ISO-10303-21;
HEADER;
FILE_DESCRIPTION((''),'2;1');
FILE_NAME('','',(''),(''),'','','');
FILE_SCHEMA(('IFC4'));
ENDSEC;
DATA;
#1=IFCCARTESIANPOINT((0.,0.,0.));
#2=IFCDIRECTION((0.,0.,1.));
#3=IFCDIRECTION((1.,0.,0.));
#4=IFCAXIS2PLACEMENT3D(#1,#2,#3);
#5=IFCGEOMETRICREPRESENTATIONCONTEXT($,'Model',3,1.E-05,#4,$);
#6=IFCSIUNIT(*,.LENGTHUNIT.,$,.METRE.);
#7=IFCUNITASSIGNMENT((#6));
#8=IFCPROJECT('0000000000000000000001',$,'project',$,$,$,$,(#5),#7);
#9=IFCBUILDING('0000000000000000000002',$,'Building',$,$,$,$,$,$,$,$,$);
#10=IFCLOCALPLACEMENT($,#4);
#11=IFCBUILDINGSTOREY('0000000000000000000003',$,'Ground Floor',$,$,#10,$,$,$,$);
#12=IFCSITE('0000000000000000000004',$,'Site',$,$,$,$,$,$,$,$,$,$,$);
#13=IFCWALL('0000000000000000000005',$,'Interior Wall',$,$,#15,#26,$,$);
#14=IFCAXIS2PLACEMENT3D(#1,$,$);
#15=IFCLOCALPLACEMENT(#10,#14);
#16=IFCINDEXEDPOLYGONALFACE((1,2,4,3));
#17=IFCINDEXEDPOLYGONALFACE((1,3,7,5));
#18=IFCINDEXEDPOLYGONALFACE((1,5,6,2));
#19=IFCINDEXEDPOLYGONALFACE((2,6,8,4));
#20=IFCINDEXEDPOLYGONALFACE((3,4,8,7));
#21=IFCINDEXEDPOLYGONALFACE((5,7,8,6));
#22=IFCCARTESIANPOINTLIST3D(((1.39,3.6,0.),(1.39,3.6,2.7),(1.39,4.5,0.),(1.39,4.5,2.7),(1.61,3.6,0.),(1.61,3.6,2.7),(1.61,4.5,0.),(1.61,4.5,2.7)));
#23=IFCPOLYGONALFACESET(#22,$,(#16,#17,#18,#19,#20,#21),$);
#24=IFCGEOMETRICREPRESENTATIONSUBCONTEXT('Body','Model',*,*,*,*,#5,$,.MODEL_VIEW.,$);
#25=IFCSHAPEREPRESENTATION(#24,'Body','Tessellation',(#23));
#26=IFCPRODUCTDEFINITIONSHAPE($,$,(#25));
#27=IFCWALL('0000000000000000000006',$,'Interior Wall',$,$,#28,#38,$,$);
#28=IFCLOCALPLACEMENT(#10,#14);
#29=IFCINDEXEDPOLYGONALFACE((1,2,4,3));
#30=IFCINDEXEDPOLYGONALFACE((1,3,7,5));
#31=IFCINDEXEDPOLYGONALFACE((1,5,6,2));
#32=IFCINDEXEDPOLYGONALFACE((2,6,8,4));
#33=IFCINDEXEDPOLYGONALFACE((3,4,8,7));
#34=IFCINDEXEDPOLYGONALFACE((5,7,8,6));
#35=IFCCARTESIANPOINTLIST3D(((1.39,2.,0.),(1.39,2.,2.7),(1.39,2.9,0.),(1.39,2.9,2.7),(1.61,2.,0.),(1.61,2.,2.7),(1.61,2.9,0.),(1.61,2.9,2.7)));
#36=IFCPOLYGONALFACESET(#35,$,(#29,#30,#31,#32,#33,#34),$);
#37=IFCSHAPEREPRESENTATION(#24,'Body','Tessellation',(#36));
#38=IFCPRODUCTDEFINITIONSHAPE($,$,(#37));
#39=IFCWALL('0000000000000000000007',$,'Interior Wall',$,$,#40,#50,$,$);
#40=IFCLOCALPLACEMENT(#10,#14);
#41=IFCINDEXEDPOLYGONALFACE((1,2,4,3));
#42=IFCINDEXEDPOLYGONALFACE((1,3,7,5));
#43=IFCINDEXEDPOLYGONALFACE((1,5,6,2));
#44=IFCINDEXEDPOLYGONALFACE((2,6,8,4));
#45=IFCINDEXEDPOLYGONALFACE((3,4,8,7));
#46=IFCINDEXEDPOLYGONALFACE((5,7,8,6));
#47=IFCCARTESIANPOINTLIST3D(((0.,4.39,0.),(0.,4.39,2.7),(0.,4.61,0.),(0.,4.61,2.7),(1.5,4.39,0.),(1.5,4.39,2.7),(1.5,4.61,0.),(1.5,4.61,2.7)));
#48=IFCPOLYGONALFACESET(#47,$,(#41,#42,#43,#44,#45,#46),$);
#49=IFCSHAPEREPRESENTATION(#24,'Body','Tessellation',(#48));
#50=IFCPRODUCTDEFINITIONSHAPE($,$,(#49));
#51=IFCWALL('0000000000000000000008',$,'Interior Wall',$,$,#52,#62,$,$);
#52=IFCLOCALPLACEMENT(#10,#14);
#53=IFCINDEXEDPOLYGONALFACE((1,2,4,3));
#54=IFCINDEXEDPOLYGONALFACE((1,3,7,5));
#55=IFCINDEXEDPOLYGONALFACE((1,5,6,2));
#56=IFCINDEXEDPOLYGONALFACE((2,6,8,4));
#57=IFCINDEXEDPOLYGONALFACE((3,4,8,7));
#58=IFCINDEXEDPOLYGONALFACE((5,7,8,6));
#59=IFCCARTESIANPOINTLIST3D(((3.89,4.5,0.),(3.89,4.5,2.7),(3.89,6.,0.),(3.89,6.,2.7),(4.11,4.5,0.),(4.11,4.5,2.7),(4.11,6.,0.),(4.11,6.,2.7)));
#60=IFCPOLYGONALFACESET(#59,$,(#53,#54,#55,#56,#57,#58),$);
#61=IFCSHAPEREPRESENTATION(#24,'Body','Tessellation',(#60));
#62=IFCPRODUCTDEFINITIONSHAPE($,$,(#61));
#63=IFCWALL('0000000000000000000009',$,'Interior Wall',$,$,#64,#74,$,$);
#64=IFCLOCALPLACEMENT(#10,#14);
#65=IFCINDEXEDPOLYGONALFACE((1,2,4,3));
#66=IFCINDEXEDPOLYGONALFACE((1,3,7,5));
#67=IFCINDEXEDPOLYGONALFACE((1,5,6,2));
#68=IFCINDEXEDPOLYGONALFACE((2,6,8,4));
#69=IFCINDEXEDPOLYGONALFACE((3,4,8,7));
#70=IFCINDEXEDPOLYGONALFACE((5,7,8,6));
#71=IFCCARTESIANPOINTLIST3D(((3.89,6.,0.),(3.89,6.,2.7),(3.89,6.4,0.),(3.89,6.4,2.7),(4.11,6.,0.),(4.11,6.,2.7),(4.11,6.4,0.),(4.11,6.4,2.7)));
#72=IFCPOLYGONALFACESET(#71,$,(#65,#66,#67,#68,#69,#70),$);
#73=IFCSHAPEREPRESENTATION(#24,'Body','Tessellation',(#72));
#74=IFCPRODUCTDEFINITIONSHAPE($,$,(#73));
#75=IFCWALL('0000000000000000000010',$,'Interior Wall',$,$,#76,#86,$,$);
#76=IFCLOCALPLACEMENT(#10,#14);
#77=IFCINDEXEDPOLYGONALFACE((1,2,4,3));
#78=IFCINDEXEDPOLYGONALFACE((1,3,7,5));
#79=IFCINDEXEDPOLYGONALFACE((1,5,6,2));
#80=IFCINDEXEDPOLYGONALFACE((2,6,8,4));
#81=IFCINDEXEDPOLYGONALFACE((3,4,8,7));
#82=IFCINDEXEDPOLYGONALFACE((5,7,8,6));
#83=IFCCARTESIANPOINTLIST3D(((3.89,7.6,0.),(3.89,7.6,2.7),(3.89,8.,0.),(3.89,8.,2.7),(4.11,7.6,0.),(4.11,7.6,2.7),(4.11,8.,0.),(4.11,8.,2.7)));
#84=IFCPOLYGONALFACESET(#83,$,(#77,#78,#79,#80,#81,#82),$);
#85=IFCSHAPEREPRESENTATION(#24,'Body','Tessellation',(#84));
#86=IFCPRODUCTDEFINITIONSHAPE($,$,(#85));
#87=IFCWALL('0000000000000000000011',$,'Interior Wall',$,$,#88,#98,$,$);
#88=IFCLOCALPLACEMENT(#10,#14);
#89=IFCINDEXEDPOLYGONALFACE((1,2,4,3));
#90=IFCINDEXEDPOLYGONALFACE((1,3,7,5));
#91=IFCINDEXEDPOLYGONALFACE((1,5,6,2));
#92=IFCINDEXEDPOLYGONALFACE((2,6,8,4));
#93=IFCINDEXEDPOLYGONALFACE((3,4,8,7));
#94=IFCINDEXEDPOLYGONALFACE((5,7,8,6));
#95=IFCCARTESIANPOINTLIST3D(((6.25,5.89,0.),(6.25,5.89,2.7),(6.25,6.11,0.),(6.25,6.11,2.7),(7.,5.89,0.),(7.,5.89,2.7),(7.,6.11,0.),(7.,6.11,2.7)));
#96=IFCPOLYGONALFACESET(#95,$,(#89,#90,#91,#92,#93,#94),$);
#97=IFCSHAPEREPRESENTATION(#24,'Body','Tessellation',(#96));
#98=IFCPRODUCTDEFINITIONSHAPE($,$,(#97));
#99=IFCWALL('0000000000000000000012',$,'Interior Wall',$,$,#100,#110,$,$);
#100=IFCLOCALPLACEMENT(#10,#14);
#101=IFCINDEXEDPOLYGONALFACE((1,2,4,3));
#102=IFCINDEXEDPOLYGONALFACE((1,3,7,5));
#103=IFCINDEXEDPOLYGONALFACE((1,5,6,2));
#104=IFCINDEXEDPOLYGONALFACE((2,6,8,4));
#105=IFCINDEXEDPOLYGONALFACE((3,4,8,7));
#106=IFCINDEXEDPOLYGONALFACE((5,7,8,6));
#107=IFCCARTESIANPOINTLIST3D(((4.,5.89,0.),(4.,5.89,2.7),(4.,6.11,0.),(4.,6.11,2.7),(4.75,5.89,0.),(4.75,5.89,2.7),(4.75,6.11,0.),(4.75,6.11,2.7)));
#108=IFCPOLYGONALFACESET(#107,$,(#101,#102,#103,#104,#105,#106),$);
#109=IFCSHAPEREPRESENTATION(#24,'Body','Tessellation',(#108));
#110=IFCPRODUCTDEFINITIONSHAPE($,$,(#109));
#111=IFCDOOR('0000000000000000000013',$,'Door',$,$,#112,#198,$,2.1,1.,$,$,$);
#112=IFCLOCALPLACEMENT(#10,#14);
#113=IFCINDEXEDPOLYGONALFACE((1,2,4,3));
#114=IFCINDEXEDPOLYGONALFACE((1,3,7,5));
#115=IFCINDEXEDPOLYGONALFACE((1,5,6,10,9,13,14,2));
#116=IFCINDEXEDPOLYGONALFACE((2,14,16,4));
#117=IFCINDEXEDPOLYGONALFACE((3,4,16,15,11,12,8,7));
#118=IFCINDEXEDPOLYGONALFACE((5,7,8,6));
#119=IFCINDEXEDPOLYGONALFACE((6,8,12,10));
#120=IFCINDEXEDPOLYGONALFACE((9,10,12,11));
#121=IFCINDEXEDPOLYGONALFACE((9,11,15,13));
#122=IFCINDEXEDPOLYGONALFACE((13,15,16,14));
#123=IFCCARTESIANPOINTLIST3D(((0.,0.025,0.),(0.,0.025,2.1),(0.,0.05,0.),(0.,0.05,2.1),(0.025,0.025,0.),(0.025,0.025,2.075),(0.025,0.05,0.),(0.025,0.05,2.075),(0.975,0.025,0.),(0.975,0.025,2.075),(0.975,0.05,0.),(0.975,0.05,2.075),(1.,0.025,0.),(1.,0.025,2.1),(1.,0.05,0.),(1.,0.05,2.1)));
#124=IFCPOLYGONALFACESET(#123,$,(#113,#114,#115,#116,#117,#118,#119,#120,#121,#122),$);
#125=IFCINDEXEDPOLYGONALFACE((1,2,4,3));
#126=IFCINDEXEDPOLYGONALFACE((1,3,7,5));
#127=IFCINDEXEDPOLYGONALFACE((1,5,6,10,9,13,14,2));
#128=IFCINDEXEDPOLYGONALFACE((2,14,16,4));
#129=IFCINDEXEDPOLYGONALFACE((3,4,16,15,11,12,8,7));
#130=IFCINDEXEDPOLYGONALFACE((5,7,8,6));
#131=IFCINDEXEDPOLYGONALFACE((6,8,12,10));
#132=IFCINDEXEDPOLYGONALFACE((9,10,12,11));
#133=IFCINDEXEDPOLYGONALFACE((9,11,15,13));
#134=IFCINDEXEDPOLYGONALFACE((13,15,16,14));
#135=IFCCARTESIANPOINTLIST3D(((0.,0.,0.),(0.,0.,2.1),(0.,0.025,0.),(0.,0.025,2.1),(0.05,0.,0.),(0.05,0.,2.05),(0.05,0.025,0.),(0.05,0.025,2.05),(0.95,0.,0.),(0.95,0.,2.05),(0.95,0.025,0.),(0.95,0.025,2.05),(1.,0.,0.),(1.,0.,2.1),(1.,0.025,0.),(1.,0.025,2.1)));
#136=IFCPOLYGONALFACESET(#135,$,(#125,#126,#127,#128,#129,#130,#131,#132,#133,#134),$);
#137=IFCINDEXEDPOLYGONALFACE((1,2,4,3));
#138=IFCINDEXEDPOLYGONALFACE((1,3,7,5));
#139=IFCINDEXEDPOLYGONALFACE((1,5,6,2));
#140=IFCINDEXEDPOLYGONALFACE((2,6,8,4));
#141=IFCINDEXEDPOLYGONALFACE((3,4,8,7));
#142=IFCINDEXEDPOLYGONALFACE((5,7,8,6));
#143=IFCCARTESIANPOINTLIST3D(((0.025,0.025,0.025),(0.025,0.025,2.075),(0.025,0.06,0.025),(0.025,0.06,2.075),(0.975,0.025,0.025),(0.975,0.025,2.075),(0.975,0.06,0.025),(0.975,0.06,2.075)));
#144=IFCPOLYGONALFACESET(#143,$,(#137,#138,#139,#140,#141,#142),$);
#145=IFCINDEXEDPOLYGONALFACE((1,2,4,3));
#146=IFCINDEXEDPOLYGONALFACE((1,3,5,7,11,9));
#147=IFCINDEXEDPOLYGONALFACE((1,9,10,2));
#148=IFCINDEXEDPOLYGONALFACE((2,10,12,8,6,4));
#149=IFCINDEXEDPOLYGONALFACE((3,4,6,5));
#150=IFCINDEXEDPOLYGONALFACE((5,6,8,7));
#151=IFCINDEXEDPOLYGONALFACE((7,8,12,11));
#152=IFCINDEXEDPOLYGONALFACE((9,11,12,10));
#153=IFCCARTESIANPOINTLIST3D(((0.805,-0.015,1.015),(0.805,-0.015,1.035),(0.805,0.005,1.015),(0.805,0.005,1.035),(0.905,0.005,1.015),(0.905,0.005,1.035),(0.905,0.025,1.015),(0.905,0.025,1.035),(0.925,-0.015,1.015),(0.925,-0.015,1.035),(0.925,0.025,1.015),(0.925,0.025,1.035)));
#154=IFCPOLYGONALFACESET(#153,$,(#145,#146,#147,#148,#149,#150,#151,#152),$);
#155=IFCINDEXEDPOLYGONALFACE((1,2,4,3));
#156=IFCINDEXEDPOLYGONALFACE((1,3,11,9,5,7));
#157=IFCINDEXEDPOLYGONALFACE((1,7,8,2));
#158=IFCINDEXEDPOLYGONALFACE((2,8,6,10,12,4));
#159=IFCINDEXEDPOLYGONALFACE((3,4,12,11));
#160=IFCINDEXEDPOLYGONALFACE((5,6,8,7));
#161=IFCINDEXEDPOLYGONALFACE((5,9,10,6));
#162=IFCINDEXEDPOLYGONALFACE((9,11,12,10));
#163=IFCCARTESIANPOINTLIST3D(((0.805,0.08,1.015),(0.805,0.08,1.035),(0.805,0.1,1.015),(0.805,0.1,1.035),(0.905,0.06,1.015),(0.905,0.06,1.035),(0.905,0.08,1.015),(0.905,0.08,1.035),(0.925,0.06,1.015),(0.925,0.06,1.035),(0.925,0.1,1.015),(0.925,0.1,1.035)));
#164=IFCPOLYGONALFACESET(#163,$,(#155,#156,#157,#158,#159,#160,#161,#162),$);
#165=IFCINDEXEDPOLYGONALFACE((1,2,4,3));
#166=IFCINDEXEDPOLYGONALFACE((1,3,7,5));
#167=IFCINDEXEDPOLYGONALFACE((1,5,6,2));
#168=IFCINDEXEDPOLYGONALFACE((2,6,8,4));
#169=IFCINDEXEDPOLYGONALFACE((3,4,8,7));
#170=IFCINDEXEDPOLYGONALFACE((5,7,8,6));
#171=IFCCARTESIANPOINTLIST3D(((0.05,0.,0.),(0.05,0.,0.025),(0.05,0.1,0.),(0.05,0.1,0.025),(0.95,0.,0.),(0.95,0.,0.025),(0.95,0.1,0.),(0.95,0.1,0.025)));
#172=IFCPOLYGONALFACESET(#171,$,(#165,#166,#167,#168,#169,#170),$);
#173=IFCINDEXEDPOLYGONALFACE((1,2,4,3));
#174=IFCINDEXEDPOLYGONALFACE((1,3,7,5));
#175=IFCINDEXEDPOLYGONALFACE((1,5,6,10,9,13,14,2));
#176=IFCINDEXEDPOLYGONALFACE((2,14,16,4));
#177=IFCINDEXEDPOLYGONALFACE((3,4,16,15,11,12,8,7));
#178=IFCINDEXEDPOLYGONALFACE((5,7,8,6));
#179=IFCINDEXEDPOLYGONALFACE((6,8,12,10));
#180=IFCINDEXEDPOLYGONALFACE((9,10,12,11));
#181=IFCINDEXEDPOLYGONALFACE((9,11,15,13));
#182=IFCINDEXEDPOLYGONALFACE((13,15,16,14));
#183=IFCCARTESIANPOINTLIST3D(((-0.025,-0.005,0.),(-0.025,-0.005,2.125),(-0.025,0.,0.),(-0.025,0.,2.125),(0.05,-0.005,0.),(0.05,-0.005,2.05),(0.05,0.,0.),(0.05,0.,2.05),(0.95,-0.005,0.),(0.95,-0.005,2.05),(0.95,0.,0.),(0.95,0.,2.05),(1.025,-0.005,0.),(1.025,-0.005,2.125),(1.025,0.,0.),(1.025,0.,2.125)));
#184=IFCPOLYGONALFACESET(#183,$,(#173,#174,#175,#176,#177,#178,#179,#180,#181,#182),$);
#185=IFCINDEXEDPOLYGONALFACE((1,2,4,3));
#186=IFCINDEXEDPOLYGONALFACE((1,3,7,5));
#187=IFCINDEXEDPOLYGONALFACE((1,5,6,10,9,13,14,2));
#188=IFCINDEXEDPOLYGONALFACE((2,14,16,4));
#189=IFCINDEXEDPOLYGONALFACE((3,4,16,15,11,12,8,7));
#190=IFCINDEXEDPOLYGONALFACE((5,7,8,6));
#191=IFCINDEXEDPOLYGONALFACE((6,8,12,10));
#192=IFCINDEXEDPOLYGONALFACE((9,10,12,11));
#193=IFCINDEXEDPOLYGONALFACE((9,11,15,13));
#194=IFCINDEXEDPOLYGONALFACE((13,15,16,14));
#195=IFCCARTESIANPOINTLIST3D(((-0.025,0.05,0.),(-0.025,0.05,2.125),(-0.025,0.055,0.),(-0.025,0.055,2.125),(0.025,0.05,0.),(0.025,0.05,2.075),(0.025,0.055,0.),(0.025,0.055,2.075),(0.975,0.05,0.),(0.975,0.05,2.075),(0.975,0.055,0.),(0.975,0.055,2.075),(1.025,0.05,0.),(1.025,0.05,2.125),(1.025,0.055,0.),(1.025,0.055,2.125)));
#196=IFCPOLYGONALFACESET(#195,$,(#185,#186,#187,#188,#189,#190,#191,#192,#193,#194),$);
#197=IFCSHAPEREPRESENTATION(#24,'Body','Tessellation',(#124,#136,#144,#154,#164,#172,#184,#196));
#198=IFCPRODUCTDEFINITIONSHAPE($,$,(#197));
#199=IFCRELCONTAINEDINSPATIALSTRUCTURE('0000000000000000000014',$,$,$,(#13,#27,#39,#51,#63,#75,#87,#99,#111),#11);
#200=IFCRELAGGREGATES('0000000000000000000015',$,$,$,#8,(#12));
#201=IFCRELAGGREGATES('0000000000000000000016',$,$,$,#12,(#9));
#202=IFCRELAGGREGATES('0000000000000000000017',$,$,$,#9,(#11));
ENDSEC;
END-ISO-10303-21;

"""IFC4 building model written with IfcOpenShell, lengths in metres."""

from ifc_helpers import new_model, si_unit, frame, origin_with_axes, place, context, subcontext, project, spatial, line, indexed_curve, outline, extrude, element, save


model = new_model("IFC4")

# Units and contexts
model_context = context("Model", 3, precision=1e-05, world=origin_with_axes())
body_context = subcontext(model_context, "Body", "Model", "MODEL_VIEW")
ifc_project = project(units=[si_unit("LENGTHUNIT", "METRE")], contexts=[model_context])

# Site, building, storey
site = spatial("IfcSite", under=ifc_project, Name="Site")
building = spatial("IfcBuilding", under=site, Name="Building")
storey_placement = place(None, origin_with_axes())
storey = spatial("IfcBuildingStorey", under=building, at=storey_placement, Name="Ground Floor")

# Walls
for number, where, z_axis, x_axis, name in (
    (1, (1.5, 4.5, 0.0), (0.0, 0.0, 1.0), (0.0, -1.0, 0.0), "Interior Wall"),
    (2, (1.5, 2.9, 0.0), (0.0, 0.0, 1.0), (0.0, -1.0, 0.0), "Interior Wall"),
):
    element("IfcWall", number, at=place(storey_placement, frame(where, z_axis=z_axis, x_axis=x_axis)), inside=storey, Name=name, context=body_context, shape_type="SweptSolid", body=[
        extrude(outline(indexed_curve([(0.0, 0.0), (0.0, 0.22), (0.9, 0.22), (0.9, 0.0), (0.0, 0.0)], self_intersect=False)), frame((0.0, -0.11, 0.0), z_axis=(0.0, 0.0, 1.0), x_axis=(1.0, 0.0, 0.0)), (0.0, 0.0, 1.0), 2.7),
    ])
for number, where, z_axis, x_axis, name in (
    (3, (1.5, 4.5, 0.0), (0.0, 0.0, 1.0), (-1.0, 0.0, 0.0), "Interior Wall"),
    (4, (4.0, 4.5, 0.0), (0.0, 0.0, 1.0), (0.0, 1.0, 0.0), "Interior Wall"),
):
    element("IfcWall", number, at=place(storey_placement, frame(where, z_axis=z_axis, x_axis=x_axis)), inside=storey, Name=name, context=body_context, shape_type="SweptSolid", body=[
        extrude(outline(indexed_curve([(0.0, 0.0), (0.0, 0.22), (1.5, 0.22), (1.5, 0.0), (0.0, 0.0)], self_intersect=False)), frame((0.0, -0.11, 0.0), z_axis=(0.0, 0.0, 1.0), x_axis=(1.0, 0.0, 0.0)), (0.0, 0.0, 1.0), 2.7),
    ])
for number, where, z_axis, x_axis, name in (
    (5, (4.0, 6.0, 0.0), (0.0, 0.0, 1.0), (0.0, 1.0, 0.0), "Interior Wall"),
    (6, (4.0, 7.6, 0.0), (0.0, 0.0, 1.0), (0.0, 1.0, 0.0), "Interior Wall"),
):
    element("IfcWall", number, at=place(storey_placement, frame(where, z_axis=z_axis, x_axis=x_axis)), inside=storey, Name=name, context=body_context, shape_type="SweptSolid", body=[
        extrude(outline(indexed_curve([(0.0, 0.0), (0.0, 0.22), (0.4, 0.22), (0.4, 0.0), (0.0, 0.0)], self_intersect=False)), frame((0.0, -0.11, 0.0), z_axis=(0.0, 0.0, 1.0), x_axis=(1.0, 0.0, 0.0)), (0.0, 0.0, 1.0), 2.7),
    ])
for number, where, z_axis, x_axis, name in (
    (7, (7.0, 6.0, 0.0), (0.0, 0.0, 1.0), (-1.0, 0.0, 0.0), "Interior Wall"),
    (8, (4.75, 6.0, 0.0), (0.0, 0.0, 1.0), (-1.0, 0.0, 0.0), "Interior Wall"),
):
    element("IfcWall", number, at=place(storey_placement, frame(where, z_axis=z_axis, x_axis=x_axis)), inside=storey, Name=name, context=body_context, shape_type="SweptSolid", body=[
        extrude(outline(indexed_curve([(0.0, 0.0), (0.0, 0.22), (0.75, 0.22), (0.75, 0.0), (0.0, 0.0)], self_intersect=False)), frame((0.0, -0.11, 0.0), z_axis=(0.0, 0.0, 1.0), x_axis=(1.0, 0.0, 0.0)), (0.0, 0.0, 1.0), 2.7),
    ])

# Door
door_1_placement = place(storey_placement, origin_with_axes())
element("IfcDoor", 9, at=door_1_placement, inside=storey, Name="Door", OverallHeight=2.1, OverallWidth=1.0, context=body_context, shape_type="SweptSolid", body=[
    extrude(outline(indexed_curve([(0.0, 0.0), (0.0, 2.1), (1.0, 2.1), (1.0, 0.0), (0.975, 0.0), (0.975, 2.075), (0.025, 2.075), (0.025, 0.0)], segments=[line(1, 2, 3, 4, 5, 6, 7, 8, 1)])), frame((0.0, 0.025, 0.0), z_axis=(0.0, -1.0, 0.0), x_axis=(1.0, 0.0, 0.0)), (0.0, 0.0, -1.0), 0.025),
    extrude(outline(indexed_curve([(0.0, 0.0), (0.0, 2.1), (1.0, 2.1), (1.0, 0.0), (0.95, 0.0), (0.95, 2.05), (0.05, 2.05), (0.05, 0.0)], segments=[line(1, 2, 3, 4, 5, 6, 7, 8, 1)])), frame((0.0, 0.0, 0.0), z_axis=(0.0, -1.0, 0.0), x_axis=(1.0, 0.0, 0.0)), (0.0, 0.0, -1.0), 0.025),
    extrude(outline(indexed_curve([(0.0, 0.0), (0.95, 0.0), (0.95, 0.035), (0.0, 0.035)], segments=[line(1, 2, 3, 4, 1)])), frame((0.025, 0.025, 0.025), z_axis=(0.0, 0.0, 1.0), x_axis=(1.0, 0.0, 0.0)), (0.0, 0.0, 1.0), 2.05),
    extrude(outline(indexed_curve([(0.0, 0.0), (0.0, -0.04), (-0.12, -0.04), (-0.12, -0.02), (-0.02, -0.02), (-0.02, 0.0)], segments=[line(1, 2, 3, 4, 5, 6, 1)])), frame((0.925, 0.025, 1.015), z_axis=(0.0, 0.0, 1.0), x_axis=(1.0, 0.0, 0.0)), (0.0, 0.0, 1.0), 0.02),
    extrude(outline(indexed_curve([(0.0, 0.0), (0.0, 0.04), (-0.12, 0.04), (-0.12, 0.02), (-0.02, 0.02), (-0.02, 0.0)], segments=[line(1, 2, 3, 4, 5, 6, 1)])), frame((0.925, 0.06, 1.015), z_axis=(0.0, 0.0, 1.0), x_axis=(1.0, 0.0, 0.0)), (0.0, 0.0, 1.0), 0.02),
    extrude(outline(indexed_curve([(0.0, 0.0), (0.9, 0.0), (0.9, 0.1), (0.0, 0.1)], segments=[line(1, 2, 3, 4, 1)])), frame((0.05, 0.0, 0.0), z_axis=(0.0, 0.0, 1.0), x_axis=(1.0, 0.0, 0.0)), (0.0, 0.0, 1.0), 0.025),
    extrude(outline(indexed_curve([(0.0, 0.0), (0.0, 2.125), (1.05, 2.125), (1.05, 0.0), (0.975, 0.0), (0.975, 2.05), (0.075, 2.05), (0.075, 0.0)], segments=[line(1, 2, 3, 4, 5, 6, 7, 8, 1)])), frame((-0.025, -0.005, 0.0), z_axis=(0.0, -1.0, 0.0), x_axis=(1.0, 0.0, 0.0)), (0.0, 0.0, -1.0), 0.005),
    extrude(outline(indexed_curve([(0.0, 0.0), (0.0, 2.125), (1.05, 2.125), (1.05, 0.0), (1.0, 0.0), (1.0, 2.075), (0.05, 2.075), (0.05, 0.0)], segments=[line(1, 2, 3, 4, 5, 6, 7, 8, 1)])), frame((-0.025, 0.05, 0.0), z_axis=(0.0, -1.0, 0.0), x_axis=(1.0, 0.0, 0.0)), (0.0, 0.0, -1.0), 0.005),
])

save(model, "model.ifc")
